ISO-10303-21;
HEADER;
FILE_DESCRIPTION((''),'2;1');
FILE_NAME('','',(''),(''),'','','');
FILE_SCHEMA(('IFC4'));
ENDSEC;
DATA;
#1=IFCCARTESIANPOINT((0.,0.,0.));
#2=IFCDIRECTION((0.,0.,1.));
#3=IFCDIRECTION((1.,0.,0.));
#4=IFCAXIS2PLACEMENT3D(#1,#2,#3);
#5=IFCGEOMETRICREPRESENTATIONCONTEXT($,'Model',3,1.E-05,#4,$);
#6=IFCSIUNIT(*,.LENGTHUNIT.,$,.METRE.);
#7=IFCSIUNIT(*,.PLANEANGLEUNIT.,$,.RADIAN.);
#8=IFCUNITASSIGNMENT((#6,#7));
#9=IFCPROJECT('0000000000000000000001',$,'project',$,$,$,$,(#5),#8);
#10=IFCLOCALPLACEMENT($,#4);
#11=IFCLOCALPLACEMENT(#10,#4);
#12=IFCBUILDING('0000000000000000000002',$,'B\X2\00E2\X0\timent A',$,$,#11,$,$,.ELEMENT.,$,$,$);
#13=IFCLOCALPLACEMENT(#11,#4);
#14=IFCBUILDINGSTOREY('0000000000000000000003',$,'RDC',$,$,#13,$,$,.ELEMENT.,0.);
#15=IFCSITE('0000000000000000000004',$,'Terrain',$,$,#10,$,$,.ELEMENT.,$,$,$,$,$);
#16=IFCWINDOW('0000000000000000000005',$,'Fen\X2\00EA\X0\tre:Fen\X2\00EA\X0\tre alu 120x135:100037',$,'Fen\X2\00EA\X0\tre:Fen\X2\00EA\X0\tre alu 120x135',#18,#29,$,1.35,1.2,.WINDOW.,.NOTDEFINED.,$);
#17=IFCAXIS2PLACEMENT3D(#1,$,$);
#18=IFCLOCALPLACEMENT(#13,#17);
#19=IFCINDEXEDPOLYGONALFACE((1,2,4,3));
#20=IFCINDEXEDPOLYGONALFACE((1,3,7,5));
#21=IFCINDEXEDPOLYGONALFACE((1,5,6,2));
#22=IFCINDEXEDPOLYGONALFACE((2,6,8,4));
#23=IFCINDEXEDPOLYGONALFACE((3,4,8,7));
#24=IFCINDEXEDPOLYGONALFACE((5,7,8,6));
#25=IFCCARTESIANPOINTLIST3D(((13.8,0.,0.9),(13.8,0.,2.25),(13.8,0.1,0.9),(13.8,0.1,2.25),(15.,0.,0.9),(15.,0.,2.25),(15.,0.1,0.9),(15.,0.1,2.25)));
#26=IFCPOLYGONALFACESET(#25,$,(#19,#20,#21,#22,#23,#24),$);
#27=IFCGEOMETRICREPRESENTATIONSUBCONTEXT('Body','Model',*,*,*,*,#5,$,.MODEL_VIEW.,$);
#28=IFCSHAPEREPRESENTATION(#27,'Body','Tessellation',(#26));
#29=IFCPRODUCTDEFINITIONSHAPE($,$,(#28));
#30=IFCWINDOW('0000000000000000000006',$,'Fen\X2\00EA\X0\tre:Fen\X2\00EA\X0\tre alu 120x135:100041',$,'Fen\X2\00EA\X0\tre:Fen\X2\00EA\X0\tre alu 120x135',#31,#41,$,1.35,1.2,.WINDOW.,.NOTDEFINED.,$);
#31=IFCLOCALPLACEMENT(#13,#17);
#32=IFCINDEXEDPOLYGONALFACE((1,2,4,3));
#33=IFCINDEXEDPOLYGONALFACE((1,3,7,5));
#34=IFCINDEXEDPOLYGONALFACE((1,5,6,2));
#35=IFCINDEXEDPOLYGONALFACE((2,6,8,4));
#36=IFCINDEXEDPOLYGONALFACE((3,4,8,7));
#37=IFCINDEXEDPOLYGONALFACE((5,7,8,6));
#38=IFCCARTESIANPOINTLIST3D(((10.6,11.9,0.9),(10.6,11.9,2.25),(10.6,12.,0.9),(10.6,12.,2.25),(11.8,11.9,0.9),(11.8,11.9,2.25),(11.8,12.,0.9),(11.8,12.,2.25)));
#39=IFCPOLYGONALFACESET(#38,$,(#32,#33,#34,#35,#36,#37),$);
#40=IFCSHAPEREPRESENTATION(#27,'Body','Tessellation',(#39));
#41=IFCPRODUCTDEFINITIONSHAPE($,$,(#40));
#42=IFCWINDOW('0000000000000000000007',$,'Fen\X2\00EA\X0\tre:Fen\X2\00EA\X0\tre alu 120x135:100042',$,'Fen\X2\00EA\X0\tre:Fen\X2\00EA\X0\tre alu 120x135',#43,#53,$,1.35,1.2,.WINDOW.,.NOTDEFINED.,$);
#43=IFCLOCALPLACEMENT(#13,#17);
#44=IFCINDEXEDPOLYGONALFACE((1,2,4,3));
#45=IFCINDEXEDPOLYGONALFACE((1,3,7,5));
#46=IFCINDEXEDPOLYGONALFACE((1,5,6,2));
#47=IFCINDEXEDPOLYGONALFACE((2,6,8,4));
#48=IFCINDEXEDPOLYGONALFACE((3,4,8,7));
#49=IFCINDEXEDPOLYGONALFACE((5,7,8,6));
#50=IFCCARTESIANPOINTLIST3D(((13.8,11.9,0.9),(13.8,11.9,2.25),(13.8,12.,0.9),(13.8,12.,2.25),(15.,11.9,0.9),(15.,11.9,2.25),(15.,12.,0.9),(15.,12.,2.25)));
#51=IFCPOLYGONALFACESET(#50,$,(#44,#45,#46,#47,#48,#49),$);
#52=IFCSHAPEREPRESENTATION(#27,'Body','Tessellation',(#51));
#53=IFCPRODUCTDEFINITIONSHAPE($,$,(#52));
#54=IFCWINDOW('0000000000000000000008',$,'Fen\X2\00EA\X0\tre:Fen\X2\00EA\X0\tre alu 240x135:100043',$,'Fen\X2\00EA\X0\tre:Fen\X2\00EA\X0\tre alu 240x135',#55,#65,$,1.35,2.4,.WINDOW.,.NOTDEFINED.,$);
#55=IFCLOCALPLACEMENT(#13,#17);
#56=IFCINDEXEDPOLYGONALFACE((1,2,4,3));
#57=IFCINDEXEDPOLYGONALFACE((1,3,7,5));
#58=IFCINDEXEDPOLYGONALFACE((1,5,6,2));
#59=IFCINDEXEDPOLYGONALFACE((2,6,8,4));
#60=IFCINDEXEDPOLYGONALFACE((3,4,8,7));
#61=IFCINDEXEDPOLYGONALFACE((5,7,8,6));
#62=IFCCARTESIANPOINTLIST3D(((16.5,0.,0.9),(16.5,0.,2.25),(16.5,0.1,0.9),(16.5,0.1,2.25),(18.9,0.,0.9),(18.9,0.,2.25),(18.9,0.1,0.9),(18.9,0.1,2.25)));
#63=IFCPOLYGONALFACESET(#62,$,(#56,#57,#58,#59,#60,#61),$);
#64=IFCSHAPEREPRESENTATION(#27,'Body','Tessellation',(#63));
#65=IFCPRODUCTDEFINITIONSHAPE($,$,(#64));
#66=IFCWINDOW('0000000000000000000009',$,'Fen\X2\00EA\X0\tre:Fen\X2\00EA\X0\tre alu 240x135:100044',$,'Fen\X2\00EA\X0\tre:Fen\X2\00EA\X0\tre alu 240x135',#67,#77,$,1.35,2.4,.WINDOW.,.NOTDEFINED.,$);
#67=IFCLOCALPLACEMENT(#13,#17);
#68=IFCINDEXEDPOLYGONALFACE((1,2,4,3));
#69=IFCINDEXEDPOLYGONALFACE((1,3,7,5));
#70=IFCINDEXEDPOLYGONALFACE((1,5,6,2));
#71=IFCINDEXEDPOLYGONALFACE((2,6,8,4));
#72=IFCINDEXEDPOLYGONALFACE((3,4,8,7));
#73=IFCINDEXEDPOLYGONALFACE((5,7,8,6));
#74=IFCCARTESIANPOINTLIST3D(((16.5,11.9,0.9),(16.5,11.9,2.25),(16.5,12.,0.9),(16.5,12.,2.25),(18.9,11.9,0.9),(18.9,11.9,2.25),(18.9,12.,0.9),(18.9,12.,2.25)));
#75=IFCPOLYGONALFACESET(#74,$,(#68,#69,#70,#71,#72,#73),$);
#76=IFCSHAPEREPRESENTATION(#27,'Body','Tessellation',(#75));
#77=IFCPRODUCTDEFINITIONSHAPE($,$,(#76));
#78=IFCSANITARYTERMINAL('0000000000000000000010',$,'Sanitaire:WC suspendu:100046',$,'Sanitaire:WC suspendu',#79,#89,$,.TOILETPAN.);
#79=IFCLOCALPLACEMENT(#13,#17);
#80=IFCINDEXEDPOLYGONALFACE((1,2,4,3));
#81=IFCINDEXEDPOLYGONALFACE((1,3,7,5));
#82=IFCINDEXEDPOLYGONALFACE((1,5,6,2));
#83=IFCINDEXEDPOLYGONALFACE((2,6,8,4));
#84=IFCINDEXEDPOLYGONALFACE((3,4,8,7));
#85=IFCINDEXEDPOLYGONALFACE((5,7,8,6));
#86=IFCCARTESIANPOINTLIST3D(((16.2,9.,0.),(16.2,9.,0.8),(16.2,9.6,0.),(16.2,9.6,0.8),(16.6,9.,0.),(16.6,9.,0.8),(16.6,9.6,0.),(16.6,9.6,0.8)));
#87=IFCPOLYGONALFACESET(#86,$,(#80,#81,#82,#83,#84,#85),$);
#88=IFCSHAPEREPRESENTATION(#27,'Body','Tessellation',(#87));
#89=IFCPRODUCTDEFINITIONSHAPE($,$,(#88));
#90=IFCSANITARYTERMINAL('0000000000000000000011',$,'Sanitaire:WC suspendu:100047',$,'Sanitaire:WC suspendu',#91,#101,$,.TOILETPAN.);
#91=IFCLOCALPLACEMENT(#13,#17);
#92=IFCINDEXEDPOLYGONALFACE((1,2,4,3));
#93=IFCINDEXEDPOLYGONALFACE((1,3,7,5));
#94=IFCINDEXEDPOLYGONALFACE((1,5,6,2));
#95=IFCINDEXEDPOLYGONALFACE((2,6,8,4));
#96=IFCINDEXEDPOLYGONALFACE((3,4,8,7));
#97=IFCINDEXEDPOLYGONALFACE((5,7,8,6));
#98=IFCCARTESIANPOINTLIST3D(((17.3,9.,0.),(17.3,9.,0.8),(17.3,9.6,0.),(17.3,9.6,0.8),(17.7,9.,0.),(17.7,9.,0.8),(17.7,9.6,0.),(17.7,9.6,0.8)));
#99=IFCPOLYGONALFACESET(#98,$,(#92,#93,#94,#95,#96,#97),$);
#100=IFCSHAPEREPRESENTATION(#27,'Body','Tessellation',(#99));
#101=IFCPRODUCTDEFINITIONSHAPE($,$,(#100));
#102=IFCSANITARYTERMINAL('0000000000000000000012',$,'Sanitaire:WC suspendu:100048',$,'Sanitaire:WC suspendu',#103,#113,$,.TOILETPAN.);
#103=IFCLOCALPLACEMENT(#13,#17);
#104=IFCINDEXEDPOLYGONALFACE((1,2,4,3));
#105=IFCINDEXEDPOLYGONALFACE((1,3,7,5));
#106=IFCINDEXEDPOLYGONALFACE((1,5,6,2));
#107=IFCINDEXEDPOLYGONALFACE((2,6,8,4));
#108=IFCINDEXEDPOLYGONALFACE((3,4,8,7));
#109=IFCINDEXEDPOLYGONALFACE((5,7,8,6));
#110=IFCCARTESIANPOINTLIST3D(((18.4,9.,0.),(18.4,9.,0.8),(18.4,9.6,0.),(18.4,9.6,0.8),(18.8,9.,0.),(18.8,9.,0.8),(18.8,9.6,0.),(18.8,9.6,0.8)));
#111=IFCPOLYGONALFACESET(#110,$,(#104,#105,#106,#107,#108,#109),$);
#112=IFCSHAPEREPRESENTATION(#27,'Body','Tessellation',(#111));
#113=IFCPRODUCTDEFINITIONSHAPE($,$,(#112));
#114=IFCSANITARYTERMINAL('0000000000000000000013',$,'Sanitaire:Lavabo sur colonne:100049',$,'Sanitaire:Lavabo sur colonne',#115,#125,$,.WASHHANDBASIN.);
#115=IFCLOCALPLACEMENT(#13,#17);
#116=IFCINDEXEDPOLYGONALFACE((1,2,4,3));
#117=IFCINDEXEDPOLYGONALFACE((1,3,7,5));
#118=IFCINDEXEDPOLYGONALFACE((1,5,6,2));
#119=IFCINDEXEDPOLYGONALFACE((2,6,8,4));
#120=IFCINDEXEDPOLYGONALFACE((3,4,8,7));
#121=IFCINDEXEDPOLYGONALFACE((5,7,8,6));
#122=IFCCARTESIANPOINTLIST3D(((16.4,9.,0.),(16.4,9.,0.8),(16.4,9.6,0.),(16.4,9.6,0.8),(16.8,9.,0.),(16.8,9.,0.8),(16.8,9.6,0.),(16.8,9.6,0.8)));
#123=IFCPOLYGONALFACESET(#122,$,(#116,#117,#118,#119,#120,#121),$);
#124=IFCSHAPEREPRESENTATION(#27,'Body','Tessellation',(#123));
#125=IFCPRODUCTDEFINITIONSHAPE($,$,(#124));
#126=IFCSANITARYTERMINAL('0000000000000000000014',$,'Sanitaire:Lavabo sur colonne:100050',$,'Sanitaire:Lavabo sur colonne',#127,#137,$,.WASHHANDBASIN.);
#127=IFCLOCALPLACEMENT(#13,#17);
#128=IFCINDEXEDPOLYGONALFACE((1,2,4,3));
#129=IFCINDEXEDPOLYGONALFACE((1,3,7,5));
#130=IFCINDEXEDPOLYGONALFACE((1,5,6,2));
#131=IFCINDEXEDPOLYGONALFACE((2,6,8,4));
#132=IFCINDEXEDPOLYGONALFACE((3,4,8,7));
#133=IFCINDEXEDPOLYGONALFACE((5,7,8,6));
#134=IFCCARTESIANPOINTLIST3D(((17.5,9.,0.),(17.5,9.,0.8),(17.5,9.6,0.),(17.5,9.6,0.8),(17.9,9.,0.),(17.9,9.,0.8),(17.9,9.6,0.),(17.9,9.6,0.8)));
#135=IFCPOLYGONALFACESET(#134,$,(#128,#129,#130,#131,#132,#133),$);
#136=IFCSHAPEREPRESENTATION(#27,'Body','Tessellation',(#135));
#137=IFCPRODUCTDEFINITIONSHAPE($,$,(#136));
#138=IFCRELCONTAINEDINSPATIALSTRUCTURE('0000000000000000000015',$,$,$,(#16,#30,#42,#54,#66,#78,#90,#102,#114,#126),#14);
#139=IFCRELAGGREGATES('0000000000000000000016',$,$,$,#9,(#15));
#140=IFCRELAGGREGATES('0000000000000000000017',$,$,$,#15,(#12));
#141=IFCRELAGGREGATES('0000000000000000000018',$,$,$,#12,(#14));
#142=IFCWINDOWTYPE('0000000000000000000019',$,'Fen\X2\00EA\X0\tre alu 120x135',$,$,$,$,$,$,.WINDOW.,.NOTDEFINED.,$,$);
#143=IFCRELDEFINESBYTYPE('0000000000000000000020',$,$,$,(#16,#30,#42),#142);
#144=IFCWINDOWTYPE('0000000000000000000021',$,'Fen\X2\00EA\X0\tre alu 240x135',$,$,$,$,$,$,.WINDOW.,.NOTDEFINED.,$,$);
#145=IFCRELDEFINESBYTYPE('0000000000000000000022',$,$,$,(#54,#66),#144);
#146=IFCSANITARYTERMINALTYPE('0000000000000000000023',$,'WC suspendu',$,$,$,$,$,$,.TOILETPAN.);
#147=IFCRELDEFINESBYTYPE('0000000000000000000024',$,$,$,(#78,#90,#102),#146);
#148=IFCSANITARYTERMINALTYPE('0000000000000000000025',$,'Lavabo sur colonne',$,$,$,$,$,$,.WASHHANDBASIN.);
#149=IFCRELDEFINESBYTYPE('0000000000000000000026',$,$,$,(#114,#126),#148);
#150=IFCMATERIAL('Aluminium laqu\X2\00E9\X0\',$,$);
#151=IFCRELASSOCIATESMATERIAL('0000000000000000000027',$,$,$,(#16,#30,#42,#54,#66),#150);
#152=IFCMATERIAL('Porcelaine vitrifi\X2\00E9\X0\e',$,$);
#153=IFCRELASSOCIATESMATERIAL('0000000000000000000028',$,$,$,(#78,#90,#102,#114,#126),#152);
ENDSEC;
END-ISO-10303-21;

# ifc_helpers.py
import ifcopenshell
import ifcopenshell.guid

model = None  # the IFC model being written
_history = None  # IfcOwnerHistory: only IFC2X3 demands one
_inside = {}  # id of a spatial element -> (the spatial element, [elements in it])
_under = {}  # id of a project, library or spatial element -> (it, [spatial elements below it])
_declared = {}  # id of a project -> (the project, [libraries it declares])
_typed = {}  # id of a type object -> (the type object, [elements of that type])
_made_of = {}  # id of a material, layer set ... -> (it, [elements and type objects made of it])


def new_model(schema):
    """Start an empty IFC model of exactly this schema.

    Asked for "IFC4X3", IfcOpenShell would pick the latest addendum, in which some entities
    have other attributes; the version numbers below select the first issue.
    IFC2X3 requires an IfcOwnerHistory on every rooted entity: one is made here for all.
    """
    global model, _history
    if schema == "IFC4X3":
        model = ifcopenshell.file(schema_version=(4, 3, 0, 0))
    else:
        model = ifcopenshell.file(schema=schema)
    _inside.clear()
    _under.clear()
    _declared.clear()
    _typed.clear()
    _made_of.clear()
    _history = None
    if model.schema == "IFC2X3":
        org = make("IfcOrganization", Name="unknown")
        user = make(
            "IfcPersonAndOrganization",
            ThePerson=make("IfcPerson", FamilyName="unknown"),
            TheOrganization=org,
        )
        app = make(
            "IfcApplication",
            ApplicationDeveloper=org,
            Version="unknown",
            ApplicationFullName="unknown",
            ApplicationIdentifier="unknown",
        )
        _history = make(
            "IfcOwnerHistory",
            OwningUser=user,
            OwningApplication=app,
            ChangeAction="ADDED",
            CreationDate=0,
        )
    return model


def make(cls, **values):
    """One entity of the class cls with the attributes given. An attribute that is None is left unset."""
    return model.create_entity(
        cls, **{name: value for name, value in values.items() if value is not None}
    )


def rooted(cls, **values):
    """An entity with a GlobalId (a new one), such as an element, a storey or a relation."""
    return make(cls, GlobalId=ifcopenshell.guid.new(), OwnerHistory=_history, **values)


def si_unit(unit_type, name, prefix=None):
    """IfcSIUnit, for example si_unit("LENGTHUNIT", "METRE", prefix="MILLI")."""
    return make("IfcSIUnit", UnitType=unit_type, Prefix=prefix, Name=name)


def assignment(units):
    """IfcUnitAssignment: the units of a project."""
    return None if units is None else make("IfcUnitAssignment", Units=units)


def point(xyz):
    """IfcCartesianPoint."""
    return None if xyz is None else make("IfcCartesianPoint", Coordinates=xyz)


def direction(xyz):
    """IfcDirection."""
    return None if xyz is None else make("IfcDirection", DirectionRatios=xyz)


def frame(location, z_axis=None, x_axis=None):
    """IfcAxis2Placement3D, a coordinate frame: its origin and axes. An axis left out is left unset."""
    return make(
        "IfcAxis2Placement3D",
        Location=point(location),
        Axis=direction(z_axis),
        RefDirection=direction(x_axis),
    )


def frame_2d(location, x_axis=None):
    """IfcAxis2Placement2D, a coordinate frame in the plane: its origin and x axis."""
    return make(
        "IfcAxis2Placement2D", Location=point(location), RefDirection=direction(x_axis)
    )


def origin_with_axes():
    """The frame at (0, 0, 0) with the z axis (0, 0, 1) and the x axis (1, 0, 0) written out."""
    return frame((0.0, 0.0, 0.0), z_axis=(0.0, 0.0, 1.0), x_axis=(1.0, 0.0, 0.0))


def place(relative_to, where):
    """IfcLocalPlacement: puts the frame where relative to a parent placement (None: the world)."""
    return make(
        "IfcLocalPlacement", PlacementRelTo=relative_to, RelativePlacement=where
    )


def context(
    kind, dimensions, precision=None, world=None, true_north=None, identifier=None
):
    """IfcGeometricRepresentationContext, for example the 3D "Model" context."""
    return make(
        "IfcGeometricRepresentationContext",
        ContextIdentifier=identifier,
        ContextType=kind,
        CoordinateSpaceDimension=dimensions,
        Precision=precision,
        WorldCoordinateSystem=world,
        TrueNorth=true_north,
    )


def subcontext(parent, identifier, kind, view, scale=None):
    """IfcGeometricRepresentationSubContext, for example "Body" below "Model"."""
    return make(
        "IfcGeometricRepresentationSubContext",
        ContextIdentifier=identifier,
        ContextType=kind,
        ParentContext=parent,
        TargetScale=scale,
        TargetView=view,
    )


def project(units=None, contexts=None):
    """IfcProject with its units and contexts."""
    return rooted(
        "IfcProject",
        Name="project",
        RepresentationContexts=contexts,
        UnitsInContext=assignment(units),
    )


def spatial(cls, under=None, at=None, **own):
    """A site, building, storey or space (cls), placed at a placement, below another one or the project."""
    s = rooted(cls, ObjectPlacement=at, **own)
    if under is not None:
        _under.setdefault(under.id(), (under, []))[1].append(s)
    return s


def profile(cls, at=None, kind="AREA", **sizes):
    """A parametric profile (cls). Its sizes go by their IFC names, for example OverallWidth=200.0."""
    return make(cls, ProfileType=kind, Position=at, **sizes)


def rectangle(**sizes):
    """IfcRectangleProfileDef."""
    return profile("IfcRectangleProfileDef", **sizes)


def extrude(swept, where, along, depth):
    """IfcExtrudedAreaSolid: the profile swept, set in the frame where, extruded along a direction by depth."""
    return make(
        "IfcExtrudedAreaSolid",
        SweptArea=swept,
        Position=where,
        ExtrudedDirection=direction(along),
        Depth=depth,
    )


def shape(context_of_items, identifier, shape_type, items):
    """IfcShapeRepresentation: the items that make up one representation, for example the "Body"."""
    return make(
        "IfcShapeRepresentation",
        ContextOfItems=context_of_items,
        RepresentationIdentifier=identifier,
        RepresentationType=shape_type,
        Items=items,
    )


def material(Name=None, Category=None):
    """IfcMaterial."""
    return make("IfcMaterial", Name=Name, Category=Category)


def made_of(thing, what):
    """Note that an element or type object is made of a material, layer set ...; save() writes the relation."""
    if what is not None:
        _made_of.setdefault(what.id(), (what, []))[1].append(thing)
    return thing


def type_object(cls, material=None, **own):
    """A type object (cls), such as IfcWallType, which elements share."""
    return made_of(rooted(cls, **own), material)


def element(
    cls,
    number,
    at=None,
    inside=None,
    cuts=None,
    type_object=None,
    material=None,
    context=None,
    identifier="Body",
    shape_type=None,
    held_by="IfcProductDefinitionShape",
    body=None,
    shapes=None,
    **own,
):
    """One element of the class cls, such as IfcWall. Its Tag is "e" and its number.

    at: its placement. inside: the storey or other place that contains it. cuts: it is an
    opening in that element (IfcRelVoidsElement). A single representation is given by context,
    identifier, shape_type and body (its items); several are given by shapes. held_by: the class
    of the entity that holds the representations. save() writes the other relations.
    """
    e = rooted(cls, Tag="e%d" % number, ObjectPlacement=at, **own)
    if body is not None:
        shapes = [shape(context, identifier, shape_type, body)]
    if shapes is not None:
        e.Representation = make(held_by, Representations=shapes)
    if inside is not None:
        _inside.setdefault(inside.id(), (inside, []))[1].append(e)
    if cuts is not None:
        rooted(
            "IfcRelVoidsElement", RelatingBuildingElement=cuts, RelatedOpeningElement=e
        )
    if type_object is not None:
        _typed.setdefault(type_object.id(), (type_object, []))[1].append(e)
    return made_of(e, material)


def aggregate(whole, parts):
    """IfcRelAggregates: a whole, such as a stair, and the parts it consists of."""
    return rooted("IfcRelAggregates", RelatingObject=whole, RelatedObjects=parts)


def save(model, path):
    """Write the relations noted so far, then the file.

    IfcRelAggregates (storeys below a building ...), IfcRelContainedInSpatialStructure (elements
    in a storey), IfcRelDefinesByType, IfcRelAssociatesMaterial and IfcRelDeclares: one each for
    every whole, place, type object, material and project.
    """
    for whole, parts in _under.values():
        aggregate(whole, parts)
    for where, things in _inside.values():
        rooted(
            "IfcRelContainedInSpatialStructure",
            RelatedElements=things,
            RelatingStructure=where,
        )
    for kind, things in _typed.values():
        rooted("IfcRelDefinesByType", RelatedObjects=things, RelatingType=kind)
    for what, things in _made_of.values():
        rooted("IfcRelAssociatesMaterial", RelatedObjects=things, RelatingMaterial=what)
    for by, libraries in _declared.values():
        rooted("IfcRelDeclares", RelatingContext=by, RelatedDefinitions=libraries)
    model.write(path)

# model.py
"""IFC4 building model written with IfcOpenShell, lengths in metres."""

from ifc_helpers import new_model, si_unit, frame, frame_2d, origin_with_axes, place, context, subcontext, project, spatial, rectangle, extrude, material, type_object, element, save


model = new_model("IFC4")

# Units and contexts
model_context = context("Model", 3, precision=1e-05, world=origin_with_axes())
body_context = subcontext(model_context, "Body", "Model", "MODEL_VIEW")
ifc_project = project(units=[si_unit("LENGTHUNIT", "METRE"), si_unit("PLANEANGLEUNIT", "RADIAN")], contexts=[model_context])

# Site, building, storey
site_placement = place(None, origin_with_axes())
site = spatial("IfcSite", under=ifc_project, at=site_placement, Name="Terrain", CompositionType="ELEMENT")
building_placement = place(site_placement, origin_with_axes())
building = spatial("IfcBuilding", under=site, at=building_placement, Name="Bâtiment A", CompositionType="ELEMENT")
storey_placement = place(building_placement, origin_with_axes())
storey = spatial("IfcBuildingStorey", under=building, at=storey_placement, Name="RDC", CompositionType="ELEMENT", Elevation=0.0)

# Windows
ifc_material_1 = material(Name="Aluminium laqué")
window_type_1 = type_object("IfcWindowType", Name="Fenêtre alu 120x135", PartitioningType="NOTDEFINED", PredefinedType="WINDOW")
for number, where, z_axis, x_axis, name in (
    (1, (13.8, 0.0, 0.9), (0.0, 0.0, 1.0), (1.0, 0.0, 0.0), "Fenêtre:Fenêtre alu 120x135:100037"),
    (2, (10.6, 11.9, 0.9), (0.0, 0.0, 1.0), (1.0, 0.0, 0.0), "Fenêtre:Fenêtre alu 120x135:100041"),
    (3, (13.8, 11.9, 0.9), (0.0, 0.0, 1.0), (1.0, 0.0, 0.0), "Fenêtre:Fenêtre alu 120x135:100042"),
):
    element("IfcWindow", number, at=place(storey_placement, frame(where, z_axis=z_axis, x_axis=x_axis)), inside=storey, type_object=window_type_1, material=ifc_material_1, Name=name, ObjectType="Fenêtre:Fenêtre alu 120x135", OverallHeight=1.35, OverallWidth=1.2, PartitioningType="NOTDEFINED", PredefinedType="WINDOW", context=body_context, shape_type="SweptSolid", body=[
        extrude(rectangle(XDim=1.2, YDim=0.1, at=frame_2d((0.6, 0.05))), origin_with_axes(), (0.0, 0.0, 1.0), 1.35),
    ])
window_type_2 = type_object("IfcWindowType", Name="Fenêtre alu 240x135", PartitioningType="NOTDEFINED", PredefinedType="WINDOW")
for number, where, z_axis, x_axis, name in (
    (4, (16.5, 0.0, 0.9), (0.0, 0.0, 1.0), (1.0, 0.0, 0.0), "Fenêtre:Fenêtre alu 240x135:100043"),
    (5, (16.5, 11.9, 0.9), (0.0, 0.0, 1.0), (1.0, 0.0, 0.0), "Fenêtre:Fenêtre alu 240x135:100044"),
):
    element("IfcWindow", number, at=place(storey_placement, frame(where, z_axis=z_axis, x_axis=x_axis)), inside=storey, type_object=window_type_2, material=ifc_material_1, Name=name, ObjectType="Fenêtre:Fenêtre alu 240x135", OverallHeight=1.35, OverallWidth=2.4, PartitioningType="NOTDEFINED", PredefinedType="WINDOW", context=body_context, shape_type="SweptSolid", body=[
        extrude(rectangle(XDim=2.4, YDim=0.1, at=frame_2d((1.2, 0.05))), origin_with_axes(), (0.0, 0.0, 1.0), 1.35),
    ])

# Sanitary terminals
ifc_material_2 = material(Name="Porcelaine vitrifiée")
sanitary_terminal_type_1 = type_object("IfcSanitaryTerminalType", Name="WC suspendu", PredefinedType="TOILETPAN")
for number, where, z_axis, x_axis, name in (
    (6, (16.2, 9.0, 0.0), (0.0, 0.0, 1.0), (1.0, 0.0, 0.0), "Sanitaire:WC suspendu:100046"),
    (7, (17.3, 9.0, 0.0), (0.0, 0.0, 1.0), (1.0, 0.0, 0.0), "Sanitaire:WC suspendu:100047"),
    (8, (18.4, 9.0, 0.0), (0.0, 0.0, 1.0), (1.0, 0.0, 0.0), "Sanitaire:WC suspendu:100048"),
):
    element("IfcSanitaryTerminal", number, at=place(storey_placement, frame(where, z_axis=z_axis, x_axis=x_axis)), inside=storey, type_object=sanitary_terminal_type_1, material=ifc_material_2, Name=name, ObjectType="Sanitaire:WC suspendu", PredefinedType="TOILETPAN", context=body_context, shape_type="SweptSolid", body=[
        extrude(rectangle(XDim=0.4, YDim=0.6, at=frame_2d((0.2, 0.3))), origin_with_axes(), (0.0, 0.0, 1.0), 0.8),
    ])
sanitary_terminal_type_2 = type_object("IfcSanitaryTerminalType", Name="Lavabo sur colonne", PredefinedType="WASHHANDBASIN")
for number, where, z_axis, x_axis, name in (
    (9, (16.4, 9.0, 0.0), (0.0, 0.0, 1.0), (1.0, 0.0, 0.0), "Sanitaire:Lavabo sur colonne:100049"),
    (10, (17.5, 9.0, 0.0), (0.0, 0.0, 1.0), (1.0, 0.0, 0.0), "Sanitaire:Lavabo sur colonne:100050"),
):
    element("IfcSanitaryTerminal", number, at=place(storey_placement, frame(where, z_axis=z_axis, x_axis=x_axis)), inside=storey, type_object=sanitary_terminal_type_2, material=ifc_material_2, Name=name, ObjectType="Sanitaire:Lavabo sur colonne", PredefinedType="WASHHANDBASIN", context=body_context, shape_type="SweptSolid", body=[
        extrude(rectangle(XDim=0.4, YDim=0.6, at=frame_2d((0.2, 0.3))), origin_with_axes(), (0.0, 0.0, 1.0), 0.8),
    ])

save(model, "model.ifc")
